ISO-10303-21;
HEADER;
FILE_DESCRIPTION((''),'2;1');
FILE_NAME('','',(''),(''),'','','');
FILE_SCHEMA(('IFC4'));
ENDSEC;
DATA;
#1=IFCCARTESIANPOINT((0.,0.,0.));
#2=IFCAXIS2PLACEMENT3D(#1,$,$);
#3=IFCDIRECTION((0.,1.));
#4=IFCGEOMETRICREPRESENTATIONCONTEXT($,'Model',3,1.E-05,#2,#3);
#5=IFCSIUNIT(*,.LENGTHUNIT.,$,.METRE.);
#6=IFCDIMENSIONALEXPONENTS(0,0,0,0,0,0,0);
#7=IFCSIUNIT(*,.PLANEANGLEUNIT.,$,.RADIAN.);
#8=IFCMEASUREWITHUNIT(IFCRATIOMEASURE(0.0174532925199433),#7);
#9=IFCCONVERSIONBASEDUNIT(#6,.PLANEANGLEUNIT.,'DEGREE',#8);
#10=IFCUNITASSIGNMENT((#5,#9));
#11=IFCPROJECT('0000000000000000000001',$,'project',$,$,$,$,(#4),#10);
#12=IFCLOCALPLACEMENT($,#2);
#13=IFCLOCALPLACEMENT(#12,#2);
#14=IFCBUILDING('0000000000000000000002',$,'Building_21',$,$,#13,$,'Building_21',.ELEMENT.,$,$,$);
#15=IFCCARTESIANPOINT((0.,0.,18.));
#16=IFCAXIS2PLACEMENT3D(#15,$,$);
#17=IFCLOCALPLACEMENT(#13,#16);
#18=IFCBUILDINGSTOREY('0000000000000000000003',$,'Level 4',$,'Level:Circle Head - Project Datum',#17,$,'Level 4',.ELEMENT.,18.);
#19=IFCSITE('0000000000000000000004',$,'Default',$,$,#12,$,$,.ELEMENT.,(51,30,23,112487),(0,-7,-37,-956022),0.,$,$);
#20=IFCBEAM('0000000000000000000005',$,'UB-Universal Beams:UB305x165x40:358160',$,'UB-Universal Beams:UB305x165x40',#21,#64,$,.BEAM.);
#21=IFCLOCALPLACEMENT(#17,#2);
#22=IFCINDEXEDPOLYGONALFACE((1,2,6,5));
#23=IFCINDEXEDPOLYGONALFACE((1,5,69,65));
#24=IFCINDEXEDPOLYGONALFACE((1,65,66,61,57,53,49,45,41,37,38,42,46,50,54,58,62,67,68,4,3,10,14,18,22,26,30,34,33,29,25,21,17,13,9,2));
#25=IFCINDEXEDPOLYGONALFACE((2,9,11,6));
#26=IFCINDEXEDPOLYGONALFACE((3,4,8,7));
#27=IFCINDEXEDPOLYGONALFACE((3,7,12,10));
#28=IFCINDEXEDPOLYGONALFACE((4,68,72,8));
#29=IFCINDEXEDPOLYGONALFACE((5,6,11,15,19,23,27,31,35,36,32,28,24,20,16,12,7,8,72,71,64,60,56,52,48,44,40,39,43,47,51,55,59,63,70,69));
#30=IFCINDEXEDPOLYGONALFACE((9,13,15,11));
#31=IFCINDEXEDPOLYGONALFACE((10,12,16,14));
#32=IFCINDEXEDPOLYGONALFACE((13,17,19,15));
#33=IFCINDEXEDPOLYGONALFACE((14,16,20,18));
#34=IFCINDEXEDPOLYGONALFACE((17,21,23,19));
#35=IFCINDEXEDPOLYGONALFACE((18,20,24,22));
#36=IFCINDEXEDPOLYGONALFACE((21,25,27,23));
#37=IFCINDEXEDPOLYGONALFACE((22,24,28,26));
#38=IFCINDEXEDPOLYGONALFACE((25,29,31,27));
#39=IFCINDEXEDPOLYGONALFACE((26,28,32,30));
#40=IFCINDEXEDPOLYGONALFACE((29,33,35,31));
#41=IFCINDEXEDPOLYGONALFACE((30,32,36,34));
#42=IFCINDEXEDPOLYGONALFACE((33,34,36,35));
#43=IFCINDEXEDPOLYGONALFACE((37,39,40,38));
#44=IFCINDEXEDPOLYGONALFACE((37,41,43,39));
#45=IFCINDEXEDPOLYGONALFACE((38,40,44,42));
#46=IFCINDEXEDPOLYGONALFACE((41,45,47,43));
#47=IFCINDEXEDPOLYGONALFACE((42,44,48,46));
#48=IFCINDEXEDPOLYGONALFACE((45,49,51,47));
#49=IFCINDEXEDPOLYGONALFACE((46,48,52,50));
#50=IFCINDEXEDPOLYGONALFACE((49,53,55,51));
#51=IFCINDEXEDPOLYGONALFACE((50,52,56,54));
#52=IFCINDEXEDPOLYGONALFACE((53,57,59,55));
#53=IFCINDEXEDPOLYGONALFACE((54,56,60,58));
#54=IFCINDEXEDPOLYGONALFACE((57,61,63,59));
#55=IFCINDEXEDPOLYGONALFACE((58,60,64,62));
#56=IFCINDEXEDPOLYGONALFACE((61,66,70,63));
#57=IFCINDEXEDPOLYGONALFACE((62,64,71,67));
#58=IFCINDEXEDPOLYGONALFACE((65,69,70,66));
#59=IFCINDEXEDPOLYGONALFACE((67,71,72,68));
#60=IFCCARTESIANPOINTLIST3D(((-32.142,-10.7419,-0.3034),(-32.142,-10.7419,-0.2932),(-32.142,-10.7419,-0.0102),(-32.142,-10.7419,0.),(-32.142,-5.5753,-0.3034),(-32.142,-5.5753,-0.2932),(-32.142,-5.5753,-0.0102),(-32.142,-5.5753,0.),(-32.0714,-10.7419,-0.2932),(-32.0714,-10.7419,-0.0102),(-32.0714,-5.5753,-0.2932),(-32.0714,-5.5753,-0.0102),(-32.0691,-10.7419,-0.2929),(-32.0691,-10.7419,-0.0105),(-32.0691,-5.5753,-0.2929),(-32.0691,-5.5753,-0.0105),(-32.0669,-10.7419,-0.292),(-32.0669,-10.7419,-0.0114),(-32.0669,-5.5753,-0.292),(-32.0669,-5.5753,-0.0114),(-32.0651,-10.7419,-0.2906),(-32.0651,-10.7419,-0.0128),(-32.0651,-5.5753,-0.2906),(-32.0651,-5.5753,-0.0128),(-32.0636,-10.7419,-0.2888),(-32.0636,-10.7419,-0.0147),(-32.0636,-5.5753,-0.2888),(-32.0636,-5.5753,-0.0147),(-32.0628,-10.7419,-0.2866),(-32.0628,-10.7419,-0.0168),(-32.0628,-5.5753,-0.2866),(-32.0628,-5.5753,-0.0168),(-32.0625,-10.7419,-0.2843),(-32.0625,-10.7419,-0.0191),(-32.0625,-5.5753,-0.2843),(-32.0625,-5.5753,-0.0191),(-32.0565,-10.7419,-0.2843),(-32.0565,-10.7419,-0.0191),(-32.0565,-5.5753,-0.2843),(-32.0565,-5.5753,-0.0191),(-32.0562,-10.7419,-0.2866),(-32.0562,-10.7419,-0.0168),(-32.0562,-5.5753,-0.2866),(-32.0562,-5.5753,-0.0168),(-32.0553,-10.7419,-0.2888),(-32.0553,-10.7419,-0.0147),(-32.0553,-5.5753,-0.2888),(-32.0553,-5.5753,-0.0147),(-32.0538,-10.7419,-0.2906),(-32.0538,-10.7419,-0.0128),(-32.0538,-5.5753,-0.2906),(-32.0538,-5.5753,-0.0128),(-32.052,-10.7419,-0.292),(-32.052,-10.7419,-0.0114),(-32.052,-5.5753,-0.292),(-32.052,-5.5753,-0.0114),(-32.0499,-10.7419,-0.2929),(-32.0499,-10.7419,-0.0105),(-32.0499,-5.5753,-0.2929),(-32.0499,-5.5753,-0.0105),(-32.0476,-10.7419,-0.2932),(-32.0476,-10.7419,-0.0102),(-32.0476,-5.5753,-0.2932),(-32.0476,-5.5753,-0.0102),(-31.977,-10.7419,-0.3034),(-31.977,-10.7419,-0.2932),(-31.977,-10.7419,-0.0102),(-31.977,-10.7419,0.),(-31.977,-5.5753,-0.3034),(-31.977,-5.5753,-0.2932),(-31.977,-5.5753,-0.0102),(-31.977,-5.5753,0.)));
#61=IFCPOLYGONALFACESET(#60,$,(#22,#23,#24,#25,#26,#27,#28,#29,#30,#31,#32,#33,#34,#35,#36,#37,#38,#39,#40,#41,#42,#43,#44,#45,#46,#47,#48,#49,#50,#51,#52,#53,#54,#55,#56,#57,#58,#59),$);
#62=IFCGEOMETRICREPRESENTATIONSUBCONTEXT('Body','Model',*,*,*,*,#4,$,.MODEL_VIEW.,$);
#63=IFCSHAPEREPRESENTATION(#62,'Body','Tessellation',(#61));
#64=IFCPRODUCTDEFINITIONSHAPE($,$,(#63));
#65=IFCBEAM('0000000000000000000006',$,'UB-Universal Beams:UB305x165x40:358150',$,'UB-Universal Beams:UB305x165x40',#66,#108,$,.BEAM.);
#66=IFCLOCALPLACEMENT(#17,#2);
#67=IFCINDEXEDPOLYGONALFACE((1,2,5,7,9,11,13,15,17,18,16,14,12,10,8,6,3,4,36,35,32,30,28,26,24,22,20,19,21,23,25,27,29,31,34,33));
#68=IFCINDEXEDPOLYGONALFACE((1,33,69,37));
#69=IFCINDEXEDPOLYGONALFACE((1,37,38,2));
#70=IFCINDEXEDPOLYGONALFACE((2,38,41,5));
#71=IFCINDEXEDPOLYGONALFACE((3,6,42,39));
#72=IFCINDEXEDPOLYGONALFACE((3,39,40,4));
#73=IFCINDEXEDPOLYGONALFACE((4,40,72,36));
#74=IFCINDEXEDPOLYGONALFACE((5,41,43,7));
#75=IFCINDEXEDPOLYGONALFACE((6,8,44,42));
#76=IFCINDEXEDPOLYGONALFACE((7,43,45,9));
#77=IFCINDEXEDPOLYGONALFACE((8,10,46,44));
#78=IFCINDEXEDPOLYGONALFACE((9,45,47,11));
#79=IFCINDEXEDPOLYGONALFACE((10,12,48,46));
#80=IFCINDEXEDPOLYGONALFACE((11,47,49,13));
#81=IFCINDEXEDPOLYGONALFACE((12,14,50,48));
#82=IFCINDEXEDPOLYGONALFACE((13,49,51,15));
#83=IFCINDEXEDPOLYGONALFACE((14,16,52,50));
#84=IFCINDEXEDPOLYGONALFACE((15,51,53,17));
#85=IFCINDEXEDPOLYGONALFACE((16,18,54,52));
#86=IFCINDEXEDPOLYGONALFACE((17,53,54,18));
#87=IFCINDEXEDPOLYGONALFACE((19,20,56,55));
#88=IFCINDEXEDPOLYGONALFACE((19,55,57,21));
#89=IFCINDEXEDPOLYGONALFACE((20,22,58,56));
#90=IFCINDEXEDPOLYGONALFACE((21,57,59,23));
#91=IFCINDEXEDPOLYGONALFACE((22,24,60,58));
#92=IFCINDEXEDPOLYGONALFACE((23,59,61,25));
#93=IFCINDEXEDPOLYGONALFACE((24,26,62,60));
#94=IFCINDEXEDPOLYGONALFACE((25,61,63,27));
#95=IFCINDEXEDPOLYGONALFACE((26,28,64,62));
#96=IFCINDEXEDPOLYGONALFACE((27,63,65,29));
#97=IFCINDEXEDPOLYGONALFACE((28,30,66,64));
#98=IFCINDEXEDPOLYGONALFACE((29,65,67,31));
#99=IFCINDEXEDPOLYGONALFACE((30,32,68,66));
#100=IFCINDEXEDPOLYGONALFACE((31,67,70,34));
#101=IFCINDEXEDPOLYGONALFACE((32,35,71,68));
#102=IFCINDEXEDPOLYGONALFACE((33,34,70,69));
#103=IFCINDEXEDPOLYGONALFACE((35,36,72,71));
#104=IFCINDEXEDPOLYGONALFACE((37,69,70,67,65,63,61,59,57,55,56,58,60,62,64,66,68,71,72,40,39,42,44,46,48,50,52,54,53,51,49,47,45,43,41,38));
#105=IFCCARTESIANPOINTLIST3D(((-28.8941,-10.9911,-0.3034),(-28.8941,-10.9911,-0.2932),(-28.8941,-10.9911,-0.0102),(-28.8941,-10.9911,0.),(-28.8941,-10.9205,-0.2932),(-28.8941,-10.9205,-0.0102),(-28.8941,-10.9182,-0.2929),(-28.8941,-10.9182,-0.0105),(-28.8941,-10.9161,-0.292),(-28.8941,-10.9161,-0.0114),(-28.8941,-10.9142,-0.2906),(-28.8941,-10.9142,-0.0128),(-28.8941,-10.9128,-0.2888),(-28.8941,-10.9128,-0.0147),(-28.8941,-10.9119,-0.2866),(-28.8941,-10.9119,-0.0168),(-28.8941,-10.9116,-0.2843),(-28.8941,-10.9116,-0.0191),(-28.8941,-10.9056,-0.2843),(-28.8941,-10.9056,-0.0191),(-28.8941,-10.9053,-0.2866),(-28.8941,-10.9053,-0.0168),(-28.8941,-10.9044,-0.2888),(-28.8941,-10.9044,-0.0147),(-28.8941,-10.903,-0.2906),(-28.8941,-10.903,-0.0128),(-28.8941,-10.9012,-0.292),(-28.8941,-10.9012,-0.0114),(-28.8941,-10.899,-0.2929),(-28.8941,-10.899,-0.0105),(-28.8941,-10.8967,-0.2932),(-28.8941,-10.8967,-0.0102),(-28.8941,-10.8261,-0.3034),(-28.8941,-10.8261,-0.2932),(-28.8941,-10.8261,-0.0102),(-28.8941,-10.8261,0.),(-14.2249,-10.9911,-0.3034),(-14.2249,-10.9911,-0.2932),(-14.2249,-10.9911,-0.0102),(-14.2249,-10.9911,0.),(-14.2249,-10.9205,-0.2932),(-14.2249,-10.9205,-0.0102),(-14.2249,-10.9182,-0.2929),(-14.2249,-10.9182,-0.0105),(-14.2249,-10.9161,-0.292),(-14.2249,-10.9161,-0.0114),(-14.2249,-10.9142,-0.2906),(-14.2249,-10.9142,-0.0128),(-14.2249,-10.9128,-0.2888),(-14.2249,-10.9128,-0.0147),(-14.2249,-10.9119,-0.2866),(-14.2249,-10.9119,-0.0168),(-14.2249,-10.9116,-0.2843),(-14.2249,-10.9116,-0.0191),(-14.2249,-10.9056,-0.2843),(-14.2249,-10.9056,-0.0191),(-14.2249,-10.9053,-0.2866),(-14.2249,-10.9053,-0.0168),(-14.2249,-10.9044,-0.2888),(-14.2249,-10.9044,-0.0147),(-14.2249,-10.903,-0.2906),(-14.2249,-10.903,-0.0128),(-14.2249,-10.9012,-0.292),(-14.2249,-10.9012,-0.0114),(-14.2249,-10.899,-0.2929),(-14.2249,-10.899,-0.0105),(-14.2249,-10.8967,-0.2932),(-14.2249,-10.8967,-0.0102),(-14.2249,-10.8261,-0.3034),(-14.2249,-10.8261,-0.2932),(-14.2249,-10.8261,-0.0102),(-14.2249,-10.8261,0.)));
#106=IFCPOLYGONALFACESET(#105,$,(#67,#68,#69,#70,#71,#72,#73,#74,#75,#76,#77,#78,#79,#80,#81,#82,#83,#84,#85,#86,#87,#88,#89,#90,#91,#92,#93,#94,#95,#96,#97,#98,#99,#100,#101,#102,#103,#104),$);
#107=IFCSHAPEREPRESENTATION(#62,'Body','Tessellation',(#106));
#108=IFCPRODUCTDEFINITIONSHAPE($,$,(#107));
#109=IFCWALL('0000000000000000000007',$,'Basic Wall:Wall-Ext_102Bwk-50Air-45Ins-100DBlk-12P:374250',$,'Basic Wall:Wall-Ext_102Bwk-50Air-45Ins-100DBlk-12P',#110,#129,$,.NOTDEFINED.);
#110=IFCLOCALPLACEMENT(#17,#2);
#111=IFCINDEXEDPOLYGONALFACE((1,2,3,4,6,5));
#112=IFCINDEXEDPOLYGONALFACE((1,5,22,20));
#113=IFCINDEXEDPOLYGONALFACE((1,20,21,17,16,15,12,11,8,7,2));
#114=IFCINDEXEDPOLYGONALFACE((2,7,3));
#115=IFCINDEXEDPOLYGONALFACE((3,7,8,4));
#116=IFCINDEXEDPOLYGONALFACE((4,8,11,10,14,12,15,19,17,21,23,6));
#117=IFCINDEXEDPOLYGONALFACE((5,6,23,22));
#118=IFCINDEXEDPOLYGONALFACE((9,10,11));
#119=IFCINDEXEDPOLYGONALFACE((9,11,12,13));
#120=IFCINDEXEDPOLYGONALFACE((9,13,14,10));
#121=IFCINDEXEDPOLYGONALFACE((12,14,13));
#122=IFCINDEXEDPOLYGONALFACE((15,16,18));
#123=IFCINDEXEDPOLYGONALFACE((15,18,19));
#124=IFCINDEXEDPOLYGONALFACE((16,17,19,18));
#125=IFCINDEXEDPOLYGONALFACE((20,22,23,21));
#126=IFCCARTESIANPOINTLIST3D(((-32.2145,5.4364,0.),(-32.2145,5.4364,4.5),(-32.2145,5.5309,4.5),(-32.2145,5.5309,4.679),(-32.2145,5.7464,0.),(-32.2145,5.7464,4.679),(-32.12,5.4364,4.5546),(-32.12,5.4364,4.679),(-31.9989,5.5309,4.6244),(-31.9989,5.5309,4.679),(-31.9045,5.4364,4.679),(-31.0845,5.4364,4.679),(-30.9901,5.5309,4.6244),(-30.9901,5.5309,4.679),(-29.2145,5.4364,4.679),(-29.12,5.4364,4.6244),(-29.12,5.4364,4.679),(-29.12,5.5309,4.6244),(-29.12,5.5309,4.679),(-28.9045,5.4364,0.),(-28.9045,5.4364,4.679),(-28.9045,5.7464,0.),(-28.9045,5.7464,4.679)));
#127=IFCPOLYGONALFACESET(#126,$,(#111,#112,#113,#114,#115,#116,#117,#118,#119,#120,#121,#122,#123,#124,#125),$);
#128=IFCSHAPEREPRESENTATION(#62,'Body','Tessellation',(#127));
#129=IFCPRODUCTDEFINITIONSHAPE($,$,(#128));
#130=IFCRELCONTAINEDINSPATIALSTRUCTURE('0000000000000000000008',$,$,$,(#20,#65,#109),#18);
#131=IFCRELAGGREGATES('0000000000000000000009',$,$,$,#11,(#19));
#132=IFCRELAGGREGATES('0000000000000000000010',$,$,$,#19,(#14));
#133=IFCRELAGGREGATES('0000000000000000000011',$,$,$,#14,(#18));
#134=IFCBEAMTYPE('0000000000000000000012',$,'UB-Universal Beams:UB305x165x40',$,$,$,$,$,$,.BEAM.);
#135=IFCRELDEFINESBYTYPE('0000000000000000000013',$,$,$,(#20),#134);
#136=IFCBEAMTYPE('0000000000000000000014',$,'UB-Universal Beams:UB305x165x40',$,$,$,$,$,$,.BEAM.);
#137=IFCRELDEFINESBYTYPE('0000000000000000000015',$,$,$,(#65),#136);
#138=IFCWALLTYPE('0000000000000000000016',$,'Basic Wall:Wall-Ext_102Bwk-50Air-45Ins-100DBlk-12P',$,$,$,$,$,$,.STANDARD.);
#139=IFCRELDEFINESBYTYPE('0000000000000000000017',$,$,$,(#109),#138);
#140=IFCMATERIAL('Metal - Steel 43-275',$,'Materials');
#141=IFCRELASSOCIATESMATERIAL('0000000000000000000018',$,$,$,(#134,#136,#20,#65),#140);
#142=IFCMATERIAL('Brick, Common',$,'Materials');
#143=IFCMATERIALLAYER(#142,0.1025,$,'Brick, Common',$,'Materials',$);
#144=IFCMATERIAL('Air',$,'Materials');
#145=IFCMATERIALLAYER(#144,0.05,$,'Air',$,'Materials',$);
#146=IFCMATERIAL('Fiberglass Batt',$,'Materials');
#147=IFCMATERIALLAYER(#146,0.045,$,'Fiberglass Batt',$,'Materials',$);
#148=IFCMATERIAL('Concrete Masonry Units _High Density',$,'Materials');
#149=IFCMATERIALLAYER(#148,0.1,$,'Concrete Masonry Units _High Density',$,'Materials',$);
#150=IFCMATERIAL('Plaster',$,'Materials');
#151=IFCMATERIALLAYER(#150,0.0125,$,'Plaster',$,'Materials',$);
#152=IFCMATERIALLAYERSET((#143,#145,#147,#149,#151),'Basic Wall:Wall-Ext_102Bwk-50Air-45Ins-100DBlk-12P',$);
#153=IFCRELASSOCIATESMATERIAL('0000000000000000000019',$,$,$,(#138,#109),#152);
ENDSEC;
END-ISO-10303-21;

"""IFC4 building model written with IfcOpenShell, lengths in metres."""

from ifc_helpers import new_model, entity, si_unit, converted_unit, direction, frame, frame_2d, origin, place, context, subcontext, project, spatial, polyline, circle_curve, parameter, trimmed, segment, composite_curve, rectangle, i_section, outline, extrude, clip, bounded_halfspace, source, transform, mapped, material, layer, layer_set, layer_usage, material_profile, profile_set, profile_usage, type_object, type_shapes, element, save


model = new_model("IFC4")

# Units and contexts
model_context = context("Model", 3, precision=1e-05, world=origin(), true_north=direction((0.0, 1.0)))
body_context = subcontext(model_context, "Body", "Model", "MODEL_VIEW")
ifc_project = project(units=[si_unit("LENGTHUNIT", "METRE"), converted_unit("PLANEANGLEUNIT", "DEGREE", entity("IfcRatioMeasure", 0.0174532925199433), si_unit("PLANEANGLEUNIT", "RADIAN"), dimensions=[0, 0, 0, 0, 0, 0, 0])], contexts=[model_context])

# Site, building, storey
site_placement = place(None, origin())
site = spatial("IfcSite", under=ifc_project, at=site_placement, Name="Default", CompositionType="ELEMENT", RefLatitude=(51, 30, 23, 112487), RefLongitude=(0, -7, -37, -956022), RefElevation=0.0)
building_placement = place(site_placement, origin())
building = spatial("IfcBuilding", under=site, at=building_placement, Name="Building_21", LongName="Building_21", CompositionType="ELEMENT")
storey_placement = place(building_placement, frame((0.0, 0.0, 18.0)))
storey = spatial("IfcBuildingStorey", under=building, at=storey_placement, Name="Level 4", ObjectType="Level:Circle Head - Project Datum", LongName="Level 4", CompositionType="ELEMENT", Elevation=18.0)

# Beams
ifc_material_1 = material(Name="Metal - Steel 43-275", Category="Materials")
ifc_material_profile_1 = material_profile(ifc_material_1, outline(composite_curve([segment(polyline([(0.0119, -0.1415, 0.0), (0.0825, -0.1415, 0.0)]), True, "CONTINUOUS"), segment(polyline([(0.0825, -0.1415, 0.0), (0.0825, -0.1517, 0.0)]), True, "CONTINUOUS"), segment(polyline([(0.0825, -0.1517, 0.0), (-0.0825, -0.1517, 0.0)]), True, "CONTINUOUS"), segment(polyline([(-0.0825, -0.1517, 0.0), (-0.0825, -0.1415, 0.0)]), True, "CONTINUOUS"), segment(polyline([(-0.0825, -0.1415, 0.0), (-0.0119, -0.1415, 0.0)]), True, "CONTINUOUS"), segment(trimmed(circle_curve(frame((-0.0119, -0.1326, 0.0), z_axis=(0.0, 0.0, 1.0), x_axis=(-1.0, 0.0, 0.0)), 0.0089), [parameter(90.0)], [parameter(180.0)], True, "PARAMETER"), True, "CONTINUOUS"), segment(polyline([(-0.003, -0.1326, 0.0), (-0.003, 0.1326, 0.0)]), True, "CONTINUOUS"), segment(trimmed(circle_curve(frame((-0.0119, 0.1326, 0.0), z_axis=(0.0, 0.0, 1.0), x_axis=(-1.0, 0.0, 0.0)), 0.0089), [parameter(180.0)], [parameter(270.0)], True, "PARAMETER"), True, "CONTINUOUS"), segment(polyline([(-0.0119, 0.1415, 0.0), (-0.0825, 0.1415, 0.0)]), True, "CONTINUOUS"), segment(polyline([(-0.0825, 0.1415, 0.0), (-0.0825, 0.1517, 0.0)]), True, "CONTINUOUS"), segment(polyline([(-0.0825, 0.1517, 0.0), (0.0825, 0.1517, 0.0)]), True, "CONTINUOUS"), segment(polyline([(0.0825, 0.1517, 0.0), (0.0825, 0.1415, 0.0)]), True, "CONTINUOUS"), segment(polyline([(0.0825, 0.1415, 0.0), (0.0119, 0.1415, 0.0)]), True, "CONTINUOUS"), segment(trimmed(circle_curve(frame((0.0119, 0.1326, 0.0), z_axis=(0.0, 0.0, 1.0), x_axis=(-1.0, 0.0, 0.0)), 0.0089), [parameter(270.0)], [parameter(0.0)], True, "PARAMETER"), True, "CONTINUOUS"), segment(polyline([(0.003, 0.1326, 0.0), (0.003, -0.1326, 0.0)]), True, "CONTINUOUS"), segment(trimmed(circle_curve(frame((0.0119, -0.1326, 0.0), z_axis=(0.0, 0.0, 1.0), x_axis=(-1.0, 0.0, 0.0)), 0.0089), [parameter(0.0)], [parameter(90.0)], True, "PARAMETER"), True, "CONTINUOUS")], self_intersect=False), kind="CURVE"), Name="UB305x165x40")
ifc_material_profile_2 = material_profile(ifc_material_1, outline(composite_curve([segment(polyline([(-1.3346, 0.0825, -0.1415), (-1.3346, 0.0825, -0.1517)]), True, "CONTINUOUS"), segment(polyline([(-1.3346, 0.0825, -0.1517), (-1.3346, -0.0825, -0.1517)]), True, "CONTINUOUS"), segment(polyline([(-1.3346, -0.0825, -0.1517), (-1.3346, -0.0825, -0.1415)]), True, "CONTINUOUS"), segment(polyline([(-1.3346, -0.0825, -0.1415), (-1.3346, -0.003, -0.1415)]), True, "CONTINUOUS"), segment(polyline([(-1.3346, -0.003, -0.1415), (-1.3346, -0.003, 0.1415)]), True, "CONTINUOUS"), segment(polyline([(-1.3346, -0.003, 0.1415), (-1.3346, -0.0825, 0.1415)]), True, "CONTINUOUS"), segment(polyline([(-1.3346, -0.0825, 0.1415), (-1.3346, -0.0825, 0.1517)]), True, "CONTINUOUS"), segment(polyline([(-1.3346, -0.0825, 0.1517), (-1.3346, 0.0825, 0.1517)]), True, "CONTINUOUS"), segment(polyline([(-1.3346, 0.0825, 0.1517), (-1.3346, 0.0825, 0.1415)]), True, "CONTINUOUS"), segment(polyline([(-1.3346, 0.0825, 0.1415), (-1.3346, 0.003, 0.1415)]), True, "CONTINUOUS"), segment(polyline([(-1.3346, 0.003, 0.1415), (-1.3346, 0.003, -0.1415)]), True, "CONTINUOUS"), segment(polyline([(-1.3346, 0.003, -0.1415), (-1.3346, 0.0825, -0.1415)]), True, "CONTINUOUS")], self_intersect=False), kind="CURVE"), Name="UB305x165x40")
ifc_profile_set = profile_set([ifc_material_profile_1, ifc_material_profile_2], Name="UB305x165x40")
beam_type_1 = type_object("IfcBeamType", Name="UB-Universal Beams:UB305x165x40", PredefinedType="BEAM", material=ifc_profile_set)
shared_shape_1 = source(origin(), body_context, "Body", "SweptSolid", [
    extrude(i_section(OverallWidth=0.165, OverallDepth=0.3034, WebThickness=0.006, FlangeThickness=0.0102, FilletRadius=0.0089, at=frame_2d((0.0, 0.0), x_axis=(0.0, 1.0))), frame((-2.5833, 0.0, 0.0), z_axis=(1.0, 0.0, 0.0), x_axis=(0.0, 0.0, -1.0)), (0.0, 0.0, 1.0), 5.1666),
])
type_shapes(beam_type_1, [shared_shape_1])
ifc_profile_usage_1 = profile_usage(ifc_profile_set, cardinal=8)
beam_1_placement = place(storey_placement, frame((-32.0595, -8.1586, -0.1517), z_axis=(0.0, 0.0, 1.0), x_axis=(0.0, -1.0, 0.0)))
element("IfcBeam", 1, at=beam_1_placement, inside=storey, type_object=beam_type_1, material=ifc_profile_usage_1, Name="UB-Universal Beams:UB305x165x40:358160", ObjectType="UB-Universal Beams:UB305x165x40", PredefinedType="BEAM", context=body_context, shape_type="MappedRepresentation", body=[
    mapped(shared_shape_1, transform((0.0, 0.0, 0.0), scale=1.0)),
])
ifc_profile_usage_2 = profile_usage(ifc_profile_set, cardinal=8)
beam_type_2 = type_object("IfcBeamType", Name="UB-Universal Beams:UB305x165x40", PredefinedType="BEAM", material=ifc_profile_set)
shared_shape_2 = source(origin(), body_context, "Body", "SweptSolid", [
    extrude(i_section(OverallWidth=0.165, OverallDepth=0.3034, WebThickness=0.006, FlangeThickness=0.0102, FilletRadius=0.0089, at=frame_2d((0.0, 0.0), x_axis=(0.0, 1.0))), frame((-7.3346, 0.0, 0.0), z_axis=(1.0, 0.0, 0.0), x_axis=(0.0, 0.0, -1.0)), (0.0, 0.0, 1.0), 14.6692),
])
type_shapes(beam_type_2, [shared_shape_2])
beam_2_placement = place(storey_placement, frame((-21.5595, -10.9086, -0.1517), z_axis=(0.0, 0.0, 1.0), x_axis=(-1.0, 0.0, 0.0)))
element("IfcBeam", 2, at=beam_2_placement, inside=storey, type_object=beam_type_2, material=ifc_profile_usage_2, Name="UB-Universal Beams:UB305x165x40:358150", ObjectType="UB-Universal Beams:UB305x165x40", PredefinedType="BEAM", context=body_context, shape_type="MappedRepresentation", body=[
    mapped(shared_shape_2, transform((0.0, 0.0, 0.0), scale=1.0)),
])

# Shared definitions
ifc_material_2 = material(Name="Air", Category="Materials")

# Wall
ifc_material_3 = material(Name="Brick, Common", Category="Materials")
ifc_layer_1 = layer(ifc_material_3, 0.1025, Name="Brick, Common", Category="Materials")
ifc_layer_2 = layer(ifc_material_2, 0.05, Name="Air", Category="Materials")
ifc_material_4 = material(Name="Fiberglass Batt", Category="Materials")
ifc_layer_3 = layer(ifc_material_4, 0.045, Name="Fiberglass Batt", Category="Materials")
ifc_material_5 = material(Name="Concrete Masonry Units _High Density", Category="Materials")
ifc_layer_4 = layer(ifc_material_5, 0.1, Name="Concrete Masonry Units _High Density", Category="Materials")
ifc_material_6 = material(Name="Plaster", Category="Materials")
ifc_layer_5 = layer(ifc_material_6, 0.0125, Name="Plaster", Category="Materials")
ifc_layer_set_1 = layer_set([ifc_layer_1, ifc_layer_2, ifc_layer_3, ifc_layer_4, ifc_layer_5], Name="Basic Wall:Wall-Ext_102Bwk-50Air-45Ins-100DBlk-12P")
ifc_layer_usage_1 = layer_usage(ifc_layer_set_1, "AXIS2", "NEGATIVE", 0.155)
wall_type = type_object("IfcWallType", Name="Basic Wall:Wall-Ext_102Bwk-50Air-45Ins-100DBlk-12P", PredefinedType="STANDARD", material=ifc_layer_set_1)
wall_1_placement = place(storey_placement, frame((-32.2145, 5.5914, 0.0)))
element("IfcWall", 3, at=wall_1_placement, inside=storey, type_object=wall_type, material=ifc_layer_usage_1, Name="Basic Wall:Wall-Ext_102Bwk-50Air-45Ins-100DBlk-12P:374250", ObjectType="Basic Wall:Wall-Ext_102Bwk-50Air-45Ins-100DBlk-12P", PredefinedType="NOTDEFINED", context=body_context, shape_type="Clipping", body=[
    clip(clip(clip(extrude(rectangle(XDim=3.31, YDim=0.31, at=frame_2d((1.655, 0.0), x_axis=(-1.0, 0.0))), origin(), (0.0, 0.0, 1.0), 4.679), bounded_halfspace(frame((0.31, -0.155, 4.679), z_axis=(0.0, 0.5, 0.866025), x_axis=(-1.0, 0.0, 0.0)), False, frame((0.31, -0.155, 4.679)), polyline([(0.0, 0.0), (0.8199, 0.0), (0.9144, 0.0945), (-0.0945, 0.0945), (0.0, 0.0)]))), bounded_halfspace(frame((3.0, -0.155, 4.679), z_axis=(0.5, 0.0, 0.866025), x_axis=(0.0, 1.0, 0.0)), False, frame((3.0, -0.155, 4.679)), polyline([(0.0, 0.0), (0.0945, 0.0), (0.0945, 0.0945), (0.0, 0.0)]))), bounded_halfspace(frame((0.0, -0.155, 4.5), z_axis=(-0.5, 0.0, 0.866025), x_axis=(0.0, -1.0, 0.0)), False, frame((0.0, -0.155, 4.5)), polyline([(0.0, 0.0), (0.0945, 0.0), (0.0, 0.0945), (0.0, 0.0)]))),
])

save(model, "model.ifc")
